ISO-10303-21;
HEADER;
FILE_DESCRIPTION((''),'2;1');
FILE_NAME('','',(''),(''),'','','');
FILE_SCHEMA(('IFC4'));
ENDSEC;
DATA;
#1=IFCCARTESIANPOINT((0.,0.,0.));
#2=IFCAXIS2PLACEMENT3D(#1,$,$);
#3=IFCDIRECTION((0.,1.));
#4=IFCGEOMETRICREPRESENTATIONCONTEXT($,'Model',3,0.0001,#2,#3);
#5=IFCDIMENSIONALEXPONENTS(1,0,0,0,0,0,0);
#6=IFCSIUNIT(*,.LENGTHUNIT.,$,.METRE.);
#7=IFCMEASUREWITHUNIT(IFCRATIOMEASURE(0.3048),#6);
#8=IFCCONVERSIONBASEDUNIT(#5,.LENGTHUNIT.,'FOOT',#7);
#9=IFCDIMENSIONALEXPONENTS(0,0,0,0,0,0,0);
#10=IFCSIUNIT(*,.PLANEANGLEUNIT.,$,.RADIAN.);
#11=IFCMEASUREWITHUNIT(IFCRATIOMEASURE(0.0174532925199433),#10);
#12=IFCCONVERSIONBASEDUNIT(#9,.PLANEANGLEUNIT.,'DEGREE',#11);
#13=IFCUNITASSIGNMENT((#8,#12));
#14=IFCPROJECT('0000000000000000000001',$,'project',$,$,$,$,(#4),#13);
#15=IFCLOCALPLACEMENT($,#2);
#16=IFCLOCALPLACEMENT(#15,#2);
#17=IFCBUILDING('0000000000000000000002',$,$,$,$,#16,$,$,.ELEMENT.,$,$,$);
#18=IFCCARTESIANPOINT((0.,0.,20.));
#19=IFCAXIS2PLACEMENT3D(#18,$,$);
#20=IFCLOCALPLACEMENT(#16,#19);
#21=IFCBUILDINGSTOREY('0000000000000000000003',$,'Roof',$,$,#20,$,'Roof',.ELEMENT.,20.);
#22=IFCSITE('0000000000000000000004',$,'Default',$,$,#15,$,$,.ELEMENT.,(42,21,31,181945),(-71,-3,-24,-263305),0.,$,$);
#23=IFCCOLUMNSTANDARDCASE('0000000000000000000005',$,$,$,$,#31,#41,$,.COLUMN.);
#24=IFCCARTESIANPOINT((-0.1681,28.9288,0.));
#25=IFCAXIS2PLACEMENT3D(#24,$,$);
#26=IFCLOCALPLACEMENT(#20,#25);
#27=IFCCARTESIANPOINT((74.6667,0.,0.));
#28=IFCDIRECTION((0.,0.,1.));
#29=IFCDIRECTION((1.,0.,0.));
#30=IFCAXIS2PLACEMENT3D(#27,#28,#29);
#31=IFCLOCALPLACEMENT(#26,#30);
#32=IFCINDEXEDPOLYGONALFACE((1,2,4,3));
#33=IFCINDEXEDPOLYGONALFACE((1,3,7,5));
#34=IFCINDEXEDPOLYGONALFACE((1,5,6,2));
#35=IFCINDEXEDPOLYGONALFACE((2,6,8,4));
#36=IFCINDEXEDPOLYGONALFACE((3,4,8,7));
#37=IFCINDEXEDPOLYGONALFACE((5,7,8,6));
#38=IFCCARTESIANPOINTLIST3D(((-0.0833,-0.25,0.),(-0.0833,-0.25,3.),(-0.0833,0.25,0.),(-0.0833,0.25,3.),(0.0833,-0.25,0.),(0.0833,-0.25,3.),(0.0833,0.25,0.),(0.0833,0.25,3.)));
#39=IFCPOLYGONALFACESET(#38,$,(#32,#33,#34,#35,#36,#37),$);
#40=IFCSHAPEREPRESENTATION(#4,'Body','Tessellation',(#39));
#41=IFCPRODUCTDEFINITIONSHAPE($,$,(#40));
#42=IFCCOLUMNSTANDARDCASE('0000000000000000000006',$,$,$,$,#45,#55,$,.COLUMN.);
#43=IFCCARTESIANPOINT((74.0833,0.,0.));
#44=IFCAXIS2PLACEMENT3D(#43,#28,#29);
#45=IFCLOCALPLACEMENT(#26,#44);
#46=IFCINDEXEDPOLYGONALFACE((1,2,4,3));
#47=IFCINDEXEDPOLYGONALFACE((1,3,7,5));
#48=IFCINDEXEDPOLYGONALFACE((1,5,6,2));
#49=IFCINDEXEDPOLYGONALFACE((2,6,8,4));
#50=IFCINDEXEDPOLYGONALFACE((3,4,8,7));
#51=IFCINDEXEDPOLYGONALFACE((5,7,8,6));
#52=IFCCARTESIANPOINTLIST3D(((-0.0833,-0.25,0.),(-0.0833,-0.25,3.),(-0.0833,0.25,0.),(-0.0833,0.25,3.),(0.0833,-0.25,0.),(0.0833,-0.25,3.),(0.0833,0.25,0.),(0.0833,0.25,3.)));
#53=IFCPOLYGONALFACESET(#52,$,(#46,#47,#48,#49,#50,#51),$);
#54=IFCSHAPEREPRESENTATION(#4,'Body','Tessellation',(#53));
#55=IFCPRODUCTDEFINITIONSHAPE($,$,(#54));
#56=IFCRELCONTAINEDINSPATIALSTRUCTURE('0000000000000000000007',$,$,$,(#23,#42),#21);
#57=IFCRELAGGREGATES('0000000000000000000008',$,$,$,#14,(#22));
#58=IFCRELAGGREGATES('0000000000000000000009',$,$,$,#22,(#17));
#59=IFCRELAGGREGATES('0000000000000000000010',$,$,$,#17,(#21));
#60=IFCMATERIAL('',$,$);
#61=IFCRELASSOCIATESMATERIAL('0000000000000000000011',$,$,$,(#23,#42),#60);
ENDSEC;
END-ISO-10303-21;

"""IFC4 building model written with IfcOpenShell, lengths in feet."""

from ifc_helpers import new_model, entity, si_unit, converted_unit, direction, frame, origin, place, context, project, spatial, rectangle, extrude, material, element, save


model = new_model("IFC4")

# Units and contexts
model_context = context("Model", 3, precision=0.0001, world=origin(), true_north=direction((0.0, 1.0)))
ifc_project = project(units=[converted_unit("LENGTHUNIT", "FOOT", entity("IfcRatioMeasure", 0.3048), si_unit("LENGTHUNIT", "METRE"), dimensions=[1, 0, 0, 0, 0, 0, 0]), converted_unit("PLANEANGLEUNIT", "DEGREE", entity("IfcRatioMeasure", 0.0174532925199433), si_unit("PLANEANGLEUNIT", "RADIAN"), dimensions=[0, 0, 0, 0, 0, 0, 0])], contexts=[model_context])

# Site, building, storey
site_placement = place(None, origin())
site = spatial("IfcSite", under=ifc_project, at=site_placement, Name="Default", CompositionType="ELEMENT", RefLatitude=(42, 21, 31, 181945), RefLongitude=(-71, -3, -24, -263305), RefElevation=0.0)
building_placement = place(site_placement, origin())
building = spatial("IfcBuilding", under=site, at=building_placement, CompositionType="ELEMENT")
storey_placement = place(building_placement, frame((0.0, 0.0, 20.0)))
storey = spatial("IfcBuildingStorey", under=building, at=storey_placement, Name="Roof", LongName="Roof", CompositionType="ELEMENT", Elevation=20.0)

# Columns
ifc_material_1 = material(Name="")
placement = place(storey_placement, frame((-0.1681, 28.9288, 0.0)))
for number, where, z_axis, x_axis in (
    (1, (74.6667, 0.0, 0.0), (0.0, 0.0, 1.0), (1.0, 0.0, 0.0)),
    (2, (74.0833, 0.0, 0.0), (0.0, 0.0, 1.0), (1.0, 0.0, 0.0)),
):
    element("IfcColumnStandardCase", number, at=place(placement, frame(where, z_axis=z_axis, x_axis=x_axis)), inside=storey, material=ifc_material_1, PredefinedType="COLUMN", context=model_context, shape_type="SweptSolid", body=[
        extrude(rectangle(XDim=0.1667, YDim=0.5), origin(), (0.0, 0.0, 1.0), 3.0),
    ])

save(model, "model.ifc")
